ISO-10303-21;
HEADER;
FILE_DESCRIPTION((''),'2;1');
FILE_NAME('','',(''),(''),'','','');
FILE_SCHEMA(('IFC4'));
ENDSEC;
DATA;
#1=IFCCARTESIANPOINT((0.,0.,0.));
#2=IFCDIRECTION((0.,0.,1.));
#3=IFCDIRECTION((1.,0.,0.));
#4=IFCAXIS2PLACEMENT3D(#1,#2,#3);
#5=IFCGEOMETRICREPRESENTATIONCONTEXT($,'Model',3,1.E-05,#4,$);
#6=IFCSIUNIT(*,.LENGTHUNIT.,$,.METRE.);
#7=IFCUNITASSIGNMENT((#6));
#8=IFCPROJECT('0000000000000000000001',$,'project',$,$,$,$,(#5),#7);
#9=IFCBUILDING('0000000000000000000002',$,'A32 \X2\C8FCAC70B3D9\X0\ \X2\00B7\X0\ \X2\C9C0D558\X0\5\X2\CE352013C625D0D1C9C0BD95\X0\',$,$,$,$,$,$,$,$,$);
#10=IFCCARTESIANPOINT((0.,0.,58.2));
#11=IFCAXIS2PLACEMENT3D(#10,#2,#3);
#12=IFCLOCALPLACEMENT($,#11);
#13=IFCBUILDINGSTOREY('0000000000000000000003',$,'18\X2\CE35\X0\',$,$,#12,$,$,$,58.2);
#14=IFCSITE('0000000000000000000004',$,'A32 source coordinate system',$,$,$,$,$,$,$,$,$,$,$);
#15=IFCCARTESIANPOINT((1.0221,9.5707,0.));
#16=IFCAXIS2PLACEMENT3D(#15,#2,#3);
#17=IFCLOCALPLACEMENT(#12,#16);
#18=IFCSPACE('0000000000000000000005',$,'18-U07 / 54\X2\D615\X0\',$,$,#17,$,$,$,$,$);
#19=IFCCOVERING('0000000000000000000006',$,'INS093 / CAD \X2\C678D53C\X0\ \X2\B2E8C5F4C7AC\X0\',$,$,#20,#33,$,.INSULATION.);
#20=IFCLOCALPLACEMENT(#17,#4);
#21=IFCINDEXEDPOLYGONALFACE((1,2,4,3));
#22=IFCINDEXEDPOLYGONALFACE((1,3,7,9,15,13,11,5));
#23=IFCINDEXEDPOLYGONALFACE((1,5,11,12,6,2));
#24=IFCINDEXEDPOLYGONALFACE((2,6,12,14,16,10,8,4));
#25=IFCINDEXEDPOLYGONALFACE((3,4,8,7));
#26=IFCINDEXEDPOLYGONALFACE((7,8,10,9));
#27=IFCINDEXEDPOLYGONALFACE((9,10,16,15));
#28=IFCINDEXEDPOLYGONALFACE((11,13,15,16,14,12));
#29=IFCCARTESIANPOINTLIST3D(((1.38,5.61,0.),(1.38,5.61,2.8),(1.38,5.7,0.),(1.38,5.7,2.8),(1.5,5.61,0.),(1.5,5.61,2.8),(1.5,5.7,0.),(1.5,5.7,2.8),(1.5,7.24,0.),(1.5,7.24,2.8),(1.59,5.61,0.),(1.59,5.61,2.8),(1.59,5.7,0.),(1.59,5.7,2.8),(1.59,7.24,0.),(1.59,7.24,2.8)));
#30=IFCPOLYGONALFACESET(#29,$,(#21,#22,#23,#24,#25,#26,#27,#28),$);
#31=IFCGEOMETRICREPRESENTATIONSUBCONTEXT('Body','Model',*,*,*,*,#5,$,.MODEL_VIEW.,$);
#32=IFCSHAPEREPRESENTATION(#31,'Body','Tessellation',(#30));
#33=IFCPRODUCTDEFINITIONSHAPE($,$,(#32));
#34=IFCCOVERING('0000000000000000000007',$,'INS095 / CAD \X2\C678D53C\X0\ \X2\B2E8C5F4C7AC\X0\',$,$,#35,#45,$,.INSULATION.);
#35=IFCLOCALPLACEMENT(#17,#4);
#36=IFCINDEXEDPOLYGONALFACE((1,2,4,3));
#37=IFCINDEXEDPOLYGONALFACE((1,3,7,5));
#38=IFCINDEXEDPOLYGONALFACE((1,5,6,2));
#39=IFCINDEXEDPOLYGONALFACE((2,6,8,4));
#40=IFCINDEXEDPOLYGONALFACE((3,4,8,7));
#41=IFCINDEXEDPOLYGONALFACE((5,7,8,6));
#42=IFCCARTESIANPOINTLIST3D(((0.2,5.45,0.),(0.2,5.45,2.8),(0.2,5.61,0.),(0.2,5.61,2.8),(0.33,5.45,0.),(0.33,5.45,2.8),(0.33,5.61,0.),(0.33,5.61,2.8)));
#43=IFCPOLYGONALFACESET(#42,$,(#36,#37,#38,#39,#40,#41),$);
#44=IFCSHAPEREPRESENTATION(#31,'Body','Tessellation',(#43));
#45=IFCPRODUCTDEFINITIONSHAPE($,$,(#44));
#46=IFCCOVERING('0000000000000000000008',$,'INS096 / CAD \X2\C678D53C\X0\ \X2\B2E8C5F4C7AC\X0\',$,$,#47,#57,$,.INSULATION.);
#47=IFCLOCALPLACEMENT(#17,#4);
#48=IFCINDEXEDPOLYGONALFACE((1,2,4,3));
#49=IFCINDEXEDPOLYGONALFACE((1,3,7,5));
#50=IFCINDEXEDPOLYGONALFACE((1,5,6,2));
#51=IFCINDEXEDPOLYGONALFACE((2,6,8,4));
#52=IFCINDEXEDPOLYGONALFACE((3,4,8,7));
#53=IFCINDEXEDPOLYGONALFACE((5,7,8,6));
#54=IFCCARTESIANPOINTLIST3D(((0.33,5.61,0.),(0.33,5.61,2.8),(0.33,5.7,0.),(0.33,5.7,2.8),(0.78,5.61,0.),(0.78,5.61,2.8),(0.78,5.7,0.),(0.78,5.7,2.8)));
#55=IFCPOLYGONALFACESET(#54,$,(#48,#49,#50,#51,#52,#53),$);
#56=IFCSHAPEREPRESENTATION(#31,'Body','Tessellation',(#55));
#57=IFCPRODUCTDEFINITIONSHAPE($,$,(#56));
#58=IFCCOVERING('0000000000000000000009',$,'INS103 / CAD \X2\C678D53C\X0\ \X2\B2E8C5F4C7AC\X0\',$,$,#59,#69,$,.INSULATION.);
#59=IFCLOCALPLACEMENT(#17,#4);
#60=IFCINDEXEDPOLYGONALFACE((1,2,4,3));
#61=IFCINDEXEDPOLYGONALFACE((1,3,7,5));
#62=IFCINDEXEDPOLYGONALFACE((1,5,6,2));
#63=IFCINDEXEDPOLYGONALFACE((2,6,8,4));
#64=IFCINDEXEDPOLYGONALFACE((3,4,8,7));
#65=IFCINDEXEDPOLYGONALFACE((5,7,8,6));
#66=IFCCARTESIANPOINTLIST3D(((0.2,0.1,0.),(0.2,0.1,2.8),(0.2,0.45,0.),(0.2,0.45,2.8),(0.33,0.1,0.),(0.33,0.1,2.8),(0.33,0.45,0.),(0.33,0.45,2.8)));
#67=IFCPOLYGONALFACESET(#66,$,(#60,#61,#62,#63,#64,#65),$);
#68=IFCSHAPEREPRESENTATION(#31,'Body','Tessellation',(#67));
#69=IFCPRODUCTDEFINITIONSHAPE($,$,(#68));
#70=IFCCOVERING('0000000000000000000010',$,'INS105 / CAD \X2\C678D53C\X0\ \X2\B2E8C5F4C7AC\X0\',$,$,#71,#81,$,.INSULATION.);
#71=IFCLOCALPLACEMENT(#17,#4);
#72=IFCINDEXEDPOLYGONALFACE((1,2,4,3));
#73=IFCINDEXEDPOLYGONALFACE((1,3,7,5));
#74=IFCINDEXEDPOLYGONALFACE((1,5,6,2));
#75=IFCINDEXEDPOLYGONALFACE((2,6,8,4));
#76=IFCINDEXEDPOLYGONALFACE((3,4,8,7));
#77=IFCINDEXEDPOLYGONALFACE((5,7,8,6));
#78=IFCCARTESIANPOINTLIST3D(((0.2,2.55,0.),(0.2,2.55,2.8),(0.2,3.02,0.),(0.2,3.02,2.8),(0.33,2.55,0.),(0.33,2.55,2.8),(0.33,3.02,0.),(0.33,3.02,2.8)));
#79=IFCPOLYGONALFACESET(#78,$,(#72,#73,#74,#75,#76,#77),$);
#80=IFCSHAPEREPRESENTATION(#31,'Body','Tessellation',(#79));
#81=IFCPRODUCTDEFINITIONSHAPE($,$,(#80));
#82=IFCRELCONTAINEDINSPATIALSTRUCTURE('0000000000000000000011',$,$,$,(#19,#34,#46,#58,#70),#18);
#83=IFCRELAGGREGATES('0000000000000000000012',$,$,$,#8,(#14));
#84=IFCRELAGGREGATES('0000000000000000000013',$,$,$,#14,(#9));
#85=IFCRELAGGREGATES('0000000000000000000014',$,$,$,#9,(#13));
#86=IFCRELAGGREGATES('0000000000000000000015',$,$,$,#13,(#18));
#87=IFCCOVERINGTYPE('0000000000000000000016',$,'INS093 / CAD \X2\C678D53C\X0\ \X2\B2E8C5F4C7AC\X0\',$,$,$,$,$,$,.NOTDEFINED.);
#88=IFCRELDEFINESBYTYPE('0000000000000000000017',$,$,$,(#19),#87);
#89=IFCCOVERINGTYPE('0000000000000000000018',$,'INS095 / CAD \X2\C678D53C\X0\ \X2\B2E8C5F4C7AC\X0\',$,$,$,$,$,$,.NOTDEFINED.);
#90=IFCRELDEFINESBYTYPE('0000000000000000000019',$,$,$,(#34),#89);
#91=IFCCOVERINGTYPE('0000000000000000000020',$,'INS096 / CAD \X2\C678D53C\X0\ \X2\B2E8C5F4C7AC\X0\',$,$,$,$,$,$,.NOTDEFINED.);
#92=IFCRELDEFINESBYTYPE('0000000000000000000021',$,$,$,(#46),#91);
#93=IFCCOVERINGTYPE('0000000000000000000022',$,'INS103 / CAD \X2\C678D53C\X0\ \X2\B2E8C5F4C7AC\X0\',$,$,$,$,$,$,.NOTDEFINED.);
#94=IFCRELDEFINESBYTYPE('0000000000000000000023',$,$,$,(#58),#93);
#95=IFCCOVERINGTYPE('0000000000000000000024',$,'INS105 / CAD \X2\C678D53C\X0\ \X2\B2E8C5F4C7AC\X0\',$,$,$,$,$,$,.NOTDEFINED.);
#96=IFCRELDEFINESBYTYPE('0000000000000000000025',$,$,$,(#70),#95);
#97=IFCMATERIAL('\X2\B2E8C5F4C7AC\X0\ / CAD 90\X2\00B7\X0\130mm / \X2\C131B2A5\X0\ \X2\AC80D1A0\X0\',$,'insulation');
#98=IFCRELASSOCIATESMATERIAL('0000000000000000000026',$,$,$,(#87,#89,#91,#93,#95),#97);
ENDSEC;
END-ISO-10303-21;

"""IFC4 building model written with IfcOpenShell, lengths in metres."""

from ifc_helpers import new_model, si_unit, frame, origin, origin_with_axes, place, context, subcontext, project, spatial, polyline, outline, extrude, source, transform, mapped, material, type_object, type_shapes, element, save


model = new_model("IFC4")

# Units and contexts
model_context = context("Model", 3, precision=1e-05, world=origin_with_axes())
body_context = subcontext(model_context, "Body", "Model", "MODEL_VIEW")
ifc_project = project(units=[si_unit("LENGTHUNIT", "METRE")], contexts=[model_context])

# Site, building, storey, space
storey_placement = place(None, frame((0.0, 0.0, 58.2), z_axis=(0.0, 0.0, 1.0), x_axis=(1.0, 0.0, 0.0)))
space_placement = place(storey_placement, frame((1.0221, 9.5707, 0.0), z_axis=(0.0, 0.0, 1.0), x_axis=(1.0, 0.0, 0.0)))
site = spatial("IfcSite", under=ifc_project, Name="A32 source coordinate system")
building = spatial("IfcBuilding", under=site, Name="A32 주거동 · 지하5층–옥탑지붕")
storey = spatial("IfcBuildingStorey", under=building, at=storey_placement, Name="18층", Elevation=58.2)
space = spatial("IfcSpace", under=storey, at=space_placement, Name="18-U07 / 54형")

# Coverings
ifc_material = material(Name="단열재 / CAD 90·130mm / 성능 검토", Category="insulation")
covering_type_1 = type_object("IfcCoveringType", Name="INS093 / CAD 외피 단열재", PredefinedType="NOTDEFINED", material=ifc_material)
shared_shape_1 = source(origin(), body_context, "Body", "SweptSolid", [
    extrude(outline(polyline([(1.5, 5.7), (1.5, 7.24), (1.59, 7.24), (1.59, 5.7), (1.59, 5.61), (1.5, 5.61), (1.38, 5.61), (1.38, 5.7), (1.5, 5.7)])), origin(), (0.0, 0.0, 1.0), 2.8),
])
type_shapes(covering_type_1, [shared_shape_1])
covering_1_placement = place(space_placement, origin_with_axes())
element("IfcCovering", 1, at=covering_1_placement, inside=space, type_object=covering_type_1, Name="INS093 / CAD 외피 단열재", PredefinedType="INSULATION", context=body_context, shape_type="MappedRepresentation", body=[
    mapped(shared_shape_1, transform((0.0, 0.0, 0.0), scale=1.0)),
])
covering_type_2 = type_object("IfcCoveringType", Name="INS095 / CAD 외피 단열재", PredefinedType="NOTDEFINED", material=ifc_material)
shared_shape_2 = source(origin(), body_context, "Body", "SweptSolid", [
    extrude(outline(polyline([(0.2, 5.61), (0.33, 5.61), (0.33, 5.45), (0.2, 5.45), (0.2, 5.61)])), origin(), (0.0, 0.0, 1.0), 2.8),
])
type_shapes(covering_type_2, [shared_shape_2])
covering_2_placement = place(space_placement, origin_with_axes())
element("IfcCovering", 2, at=covering_2_placement, inside=space, type_object=covering_type_2, Name="INS095 / CAD 외피 단열재", PredefinedType="INSULATION", context=body_context, shape_type="MappedRepresentation", body=[
    mapped(shared_shape_2, transform((0.0, 0.0, 0.0), scale=1.0)),
])
covering_type_3 = type_object("IfcCoveringType", Name="INS096 / CAD 외피 단열재", PredefinedType="NOTDEFINED", material=ifc_material)
shared_shape_3 = source(origin(), body_context, "Body", "SweptSolid", [
    extrude(outline(polyline([(0.78, 5.7), (0.78, 5.61), (0.33, 5.61), (0.33, 5.7), (0.78, 5.7)])), origin(), (0.0, 0.0, 1.0), 2.8),
])
type_shapes(covering_type_3, [shared_shape_3])
covering_3_placement = place(space_placement, origin_with_axes())
element("IfcCovering", 3, at=covering_3_placement, inside=space, type_object=covering_type_3, Name="INS096 / CAD 외피 단열재", PredefinedType="INSULATION", context=body_context, shape_type="MappedRepresentation", body=[
    mapped(shared_shape_3, transform((0.0, 0.0, 0.0), scale=1.0)),
])
covering_type_4 = type_object("IfcCoveringType", Name="INS103 / CAD 외피 단열재", PredefinedType="NOTDEFINED", material=ifc_material)
shared_shape_4 = source(origin(), body_context, "Body", "SweptSolid", [
    extrude(outline(polyline([(0.2, 0.45), (0.33, 0.45), (0.33, 0.1), (0.2, 0.1), (0.2, 0.45)])), origin(), (0.0, 0.0, 1.0), 2.8),
])
type_shapes(covering_type_4, [shared_shape_4])
covering_4_placement = place(space_placement, origin_with_axes())
element("IfcCovering", 4, at=covering_4_placement, inside=space, type_object=covering_type_4, Name="INS103 / CAD 외피 단열재", PredefinedType="INSULATION", context=body_context, shape_type="MappedRepresentation", body=[
    mapped(shared_shape_4, transform((0.0, 0.0, 0.0), scale=1.0)),
])
covering_type_5 = type_object("IfcCoveringType", Name="INS105 / CAD 외피 단열재", PredefinedType="NOTDEFINED", material=ifc_material)
shared_shape_5 = source(origin(), body_context, "Body", "SweptSolid", [
    extrude(outline(polyline([(0.2, 3.02), (0.33, 3.02), (0.33, 2.55), (0.2, 2.55), (0.2, 3.02)])), origin(), (0.0, 0.0, 1.0), 2.8),
])
type_shapes(covering_type_5, [shared_shape_5])
covering_5_placement = place(space_placement, origin_with_axes())
element("IfcCovering", 5, at=covering_5_placement, inside=space, type_object=covering_type_5, Name="INS105 / CAD 외피 단열재", PredefinedType="INSULATION", context=body_context, shape_type="MappedRepresentation", body=[
    mapped(shared_shape_5, transform((0.0, 0.0, 0.0), scale=1.0)),
])

save(model, "model.ifc")
